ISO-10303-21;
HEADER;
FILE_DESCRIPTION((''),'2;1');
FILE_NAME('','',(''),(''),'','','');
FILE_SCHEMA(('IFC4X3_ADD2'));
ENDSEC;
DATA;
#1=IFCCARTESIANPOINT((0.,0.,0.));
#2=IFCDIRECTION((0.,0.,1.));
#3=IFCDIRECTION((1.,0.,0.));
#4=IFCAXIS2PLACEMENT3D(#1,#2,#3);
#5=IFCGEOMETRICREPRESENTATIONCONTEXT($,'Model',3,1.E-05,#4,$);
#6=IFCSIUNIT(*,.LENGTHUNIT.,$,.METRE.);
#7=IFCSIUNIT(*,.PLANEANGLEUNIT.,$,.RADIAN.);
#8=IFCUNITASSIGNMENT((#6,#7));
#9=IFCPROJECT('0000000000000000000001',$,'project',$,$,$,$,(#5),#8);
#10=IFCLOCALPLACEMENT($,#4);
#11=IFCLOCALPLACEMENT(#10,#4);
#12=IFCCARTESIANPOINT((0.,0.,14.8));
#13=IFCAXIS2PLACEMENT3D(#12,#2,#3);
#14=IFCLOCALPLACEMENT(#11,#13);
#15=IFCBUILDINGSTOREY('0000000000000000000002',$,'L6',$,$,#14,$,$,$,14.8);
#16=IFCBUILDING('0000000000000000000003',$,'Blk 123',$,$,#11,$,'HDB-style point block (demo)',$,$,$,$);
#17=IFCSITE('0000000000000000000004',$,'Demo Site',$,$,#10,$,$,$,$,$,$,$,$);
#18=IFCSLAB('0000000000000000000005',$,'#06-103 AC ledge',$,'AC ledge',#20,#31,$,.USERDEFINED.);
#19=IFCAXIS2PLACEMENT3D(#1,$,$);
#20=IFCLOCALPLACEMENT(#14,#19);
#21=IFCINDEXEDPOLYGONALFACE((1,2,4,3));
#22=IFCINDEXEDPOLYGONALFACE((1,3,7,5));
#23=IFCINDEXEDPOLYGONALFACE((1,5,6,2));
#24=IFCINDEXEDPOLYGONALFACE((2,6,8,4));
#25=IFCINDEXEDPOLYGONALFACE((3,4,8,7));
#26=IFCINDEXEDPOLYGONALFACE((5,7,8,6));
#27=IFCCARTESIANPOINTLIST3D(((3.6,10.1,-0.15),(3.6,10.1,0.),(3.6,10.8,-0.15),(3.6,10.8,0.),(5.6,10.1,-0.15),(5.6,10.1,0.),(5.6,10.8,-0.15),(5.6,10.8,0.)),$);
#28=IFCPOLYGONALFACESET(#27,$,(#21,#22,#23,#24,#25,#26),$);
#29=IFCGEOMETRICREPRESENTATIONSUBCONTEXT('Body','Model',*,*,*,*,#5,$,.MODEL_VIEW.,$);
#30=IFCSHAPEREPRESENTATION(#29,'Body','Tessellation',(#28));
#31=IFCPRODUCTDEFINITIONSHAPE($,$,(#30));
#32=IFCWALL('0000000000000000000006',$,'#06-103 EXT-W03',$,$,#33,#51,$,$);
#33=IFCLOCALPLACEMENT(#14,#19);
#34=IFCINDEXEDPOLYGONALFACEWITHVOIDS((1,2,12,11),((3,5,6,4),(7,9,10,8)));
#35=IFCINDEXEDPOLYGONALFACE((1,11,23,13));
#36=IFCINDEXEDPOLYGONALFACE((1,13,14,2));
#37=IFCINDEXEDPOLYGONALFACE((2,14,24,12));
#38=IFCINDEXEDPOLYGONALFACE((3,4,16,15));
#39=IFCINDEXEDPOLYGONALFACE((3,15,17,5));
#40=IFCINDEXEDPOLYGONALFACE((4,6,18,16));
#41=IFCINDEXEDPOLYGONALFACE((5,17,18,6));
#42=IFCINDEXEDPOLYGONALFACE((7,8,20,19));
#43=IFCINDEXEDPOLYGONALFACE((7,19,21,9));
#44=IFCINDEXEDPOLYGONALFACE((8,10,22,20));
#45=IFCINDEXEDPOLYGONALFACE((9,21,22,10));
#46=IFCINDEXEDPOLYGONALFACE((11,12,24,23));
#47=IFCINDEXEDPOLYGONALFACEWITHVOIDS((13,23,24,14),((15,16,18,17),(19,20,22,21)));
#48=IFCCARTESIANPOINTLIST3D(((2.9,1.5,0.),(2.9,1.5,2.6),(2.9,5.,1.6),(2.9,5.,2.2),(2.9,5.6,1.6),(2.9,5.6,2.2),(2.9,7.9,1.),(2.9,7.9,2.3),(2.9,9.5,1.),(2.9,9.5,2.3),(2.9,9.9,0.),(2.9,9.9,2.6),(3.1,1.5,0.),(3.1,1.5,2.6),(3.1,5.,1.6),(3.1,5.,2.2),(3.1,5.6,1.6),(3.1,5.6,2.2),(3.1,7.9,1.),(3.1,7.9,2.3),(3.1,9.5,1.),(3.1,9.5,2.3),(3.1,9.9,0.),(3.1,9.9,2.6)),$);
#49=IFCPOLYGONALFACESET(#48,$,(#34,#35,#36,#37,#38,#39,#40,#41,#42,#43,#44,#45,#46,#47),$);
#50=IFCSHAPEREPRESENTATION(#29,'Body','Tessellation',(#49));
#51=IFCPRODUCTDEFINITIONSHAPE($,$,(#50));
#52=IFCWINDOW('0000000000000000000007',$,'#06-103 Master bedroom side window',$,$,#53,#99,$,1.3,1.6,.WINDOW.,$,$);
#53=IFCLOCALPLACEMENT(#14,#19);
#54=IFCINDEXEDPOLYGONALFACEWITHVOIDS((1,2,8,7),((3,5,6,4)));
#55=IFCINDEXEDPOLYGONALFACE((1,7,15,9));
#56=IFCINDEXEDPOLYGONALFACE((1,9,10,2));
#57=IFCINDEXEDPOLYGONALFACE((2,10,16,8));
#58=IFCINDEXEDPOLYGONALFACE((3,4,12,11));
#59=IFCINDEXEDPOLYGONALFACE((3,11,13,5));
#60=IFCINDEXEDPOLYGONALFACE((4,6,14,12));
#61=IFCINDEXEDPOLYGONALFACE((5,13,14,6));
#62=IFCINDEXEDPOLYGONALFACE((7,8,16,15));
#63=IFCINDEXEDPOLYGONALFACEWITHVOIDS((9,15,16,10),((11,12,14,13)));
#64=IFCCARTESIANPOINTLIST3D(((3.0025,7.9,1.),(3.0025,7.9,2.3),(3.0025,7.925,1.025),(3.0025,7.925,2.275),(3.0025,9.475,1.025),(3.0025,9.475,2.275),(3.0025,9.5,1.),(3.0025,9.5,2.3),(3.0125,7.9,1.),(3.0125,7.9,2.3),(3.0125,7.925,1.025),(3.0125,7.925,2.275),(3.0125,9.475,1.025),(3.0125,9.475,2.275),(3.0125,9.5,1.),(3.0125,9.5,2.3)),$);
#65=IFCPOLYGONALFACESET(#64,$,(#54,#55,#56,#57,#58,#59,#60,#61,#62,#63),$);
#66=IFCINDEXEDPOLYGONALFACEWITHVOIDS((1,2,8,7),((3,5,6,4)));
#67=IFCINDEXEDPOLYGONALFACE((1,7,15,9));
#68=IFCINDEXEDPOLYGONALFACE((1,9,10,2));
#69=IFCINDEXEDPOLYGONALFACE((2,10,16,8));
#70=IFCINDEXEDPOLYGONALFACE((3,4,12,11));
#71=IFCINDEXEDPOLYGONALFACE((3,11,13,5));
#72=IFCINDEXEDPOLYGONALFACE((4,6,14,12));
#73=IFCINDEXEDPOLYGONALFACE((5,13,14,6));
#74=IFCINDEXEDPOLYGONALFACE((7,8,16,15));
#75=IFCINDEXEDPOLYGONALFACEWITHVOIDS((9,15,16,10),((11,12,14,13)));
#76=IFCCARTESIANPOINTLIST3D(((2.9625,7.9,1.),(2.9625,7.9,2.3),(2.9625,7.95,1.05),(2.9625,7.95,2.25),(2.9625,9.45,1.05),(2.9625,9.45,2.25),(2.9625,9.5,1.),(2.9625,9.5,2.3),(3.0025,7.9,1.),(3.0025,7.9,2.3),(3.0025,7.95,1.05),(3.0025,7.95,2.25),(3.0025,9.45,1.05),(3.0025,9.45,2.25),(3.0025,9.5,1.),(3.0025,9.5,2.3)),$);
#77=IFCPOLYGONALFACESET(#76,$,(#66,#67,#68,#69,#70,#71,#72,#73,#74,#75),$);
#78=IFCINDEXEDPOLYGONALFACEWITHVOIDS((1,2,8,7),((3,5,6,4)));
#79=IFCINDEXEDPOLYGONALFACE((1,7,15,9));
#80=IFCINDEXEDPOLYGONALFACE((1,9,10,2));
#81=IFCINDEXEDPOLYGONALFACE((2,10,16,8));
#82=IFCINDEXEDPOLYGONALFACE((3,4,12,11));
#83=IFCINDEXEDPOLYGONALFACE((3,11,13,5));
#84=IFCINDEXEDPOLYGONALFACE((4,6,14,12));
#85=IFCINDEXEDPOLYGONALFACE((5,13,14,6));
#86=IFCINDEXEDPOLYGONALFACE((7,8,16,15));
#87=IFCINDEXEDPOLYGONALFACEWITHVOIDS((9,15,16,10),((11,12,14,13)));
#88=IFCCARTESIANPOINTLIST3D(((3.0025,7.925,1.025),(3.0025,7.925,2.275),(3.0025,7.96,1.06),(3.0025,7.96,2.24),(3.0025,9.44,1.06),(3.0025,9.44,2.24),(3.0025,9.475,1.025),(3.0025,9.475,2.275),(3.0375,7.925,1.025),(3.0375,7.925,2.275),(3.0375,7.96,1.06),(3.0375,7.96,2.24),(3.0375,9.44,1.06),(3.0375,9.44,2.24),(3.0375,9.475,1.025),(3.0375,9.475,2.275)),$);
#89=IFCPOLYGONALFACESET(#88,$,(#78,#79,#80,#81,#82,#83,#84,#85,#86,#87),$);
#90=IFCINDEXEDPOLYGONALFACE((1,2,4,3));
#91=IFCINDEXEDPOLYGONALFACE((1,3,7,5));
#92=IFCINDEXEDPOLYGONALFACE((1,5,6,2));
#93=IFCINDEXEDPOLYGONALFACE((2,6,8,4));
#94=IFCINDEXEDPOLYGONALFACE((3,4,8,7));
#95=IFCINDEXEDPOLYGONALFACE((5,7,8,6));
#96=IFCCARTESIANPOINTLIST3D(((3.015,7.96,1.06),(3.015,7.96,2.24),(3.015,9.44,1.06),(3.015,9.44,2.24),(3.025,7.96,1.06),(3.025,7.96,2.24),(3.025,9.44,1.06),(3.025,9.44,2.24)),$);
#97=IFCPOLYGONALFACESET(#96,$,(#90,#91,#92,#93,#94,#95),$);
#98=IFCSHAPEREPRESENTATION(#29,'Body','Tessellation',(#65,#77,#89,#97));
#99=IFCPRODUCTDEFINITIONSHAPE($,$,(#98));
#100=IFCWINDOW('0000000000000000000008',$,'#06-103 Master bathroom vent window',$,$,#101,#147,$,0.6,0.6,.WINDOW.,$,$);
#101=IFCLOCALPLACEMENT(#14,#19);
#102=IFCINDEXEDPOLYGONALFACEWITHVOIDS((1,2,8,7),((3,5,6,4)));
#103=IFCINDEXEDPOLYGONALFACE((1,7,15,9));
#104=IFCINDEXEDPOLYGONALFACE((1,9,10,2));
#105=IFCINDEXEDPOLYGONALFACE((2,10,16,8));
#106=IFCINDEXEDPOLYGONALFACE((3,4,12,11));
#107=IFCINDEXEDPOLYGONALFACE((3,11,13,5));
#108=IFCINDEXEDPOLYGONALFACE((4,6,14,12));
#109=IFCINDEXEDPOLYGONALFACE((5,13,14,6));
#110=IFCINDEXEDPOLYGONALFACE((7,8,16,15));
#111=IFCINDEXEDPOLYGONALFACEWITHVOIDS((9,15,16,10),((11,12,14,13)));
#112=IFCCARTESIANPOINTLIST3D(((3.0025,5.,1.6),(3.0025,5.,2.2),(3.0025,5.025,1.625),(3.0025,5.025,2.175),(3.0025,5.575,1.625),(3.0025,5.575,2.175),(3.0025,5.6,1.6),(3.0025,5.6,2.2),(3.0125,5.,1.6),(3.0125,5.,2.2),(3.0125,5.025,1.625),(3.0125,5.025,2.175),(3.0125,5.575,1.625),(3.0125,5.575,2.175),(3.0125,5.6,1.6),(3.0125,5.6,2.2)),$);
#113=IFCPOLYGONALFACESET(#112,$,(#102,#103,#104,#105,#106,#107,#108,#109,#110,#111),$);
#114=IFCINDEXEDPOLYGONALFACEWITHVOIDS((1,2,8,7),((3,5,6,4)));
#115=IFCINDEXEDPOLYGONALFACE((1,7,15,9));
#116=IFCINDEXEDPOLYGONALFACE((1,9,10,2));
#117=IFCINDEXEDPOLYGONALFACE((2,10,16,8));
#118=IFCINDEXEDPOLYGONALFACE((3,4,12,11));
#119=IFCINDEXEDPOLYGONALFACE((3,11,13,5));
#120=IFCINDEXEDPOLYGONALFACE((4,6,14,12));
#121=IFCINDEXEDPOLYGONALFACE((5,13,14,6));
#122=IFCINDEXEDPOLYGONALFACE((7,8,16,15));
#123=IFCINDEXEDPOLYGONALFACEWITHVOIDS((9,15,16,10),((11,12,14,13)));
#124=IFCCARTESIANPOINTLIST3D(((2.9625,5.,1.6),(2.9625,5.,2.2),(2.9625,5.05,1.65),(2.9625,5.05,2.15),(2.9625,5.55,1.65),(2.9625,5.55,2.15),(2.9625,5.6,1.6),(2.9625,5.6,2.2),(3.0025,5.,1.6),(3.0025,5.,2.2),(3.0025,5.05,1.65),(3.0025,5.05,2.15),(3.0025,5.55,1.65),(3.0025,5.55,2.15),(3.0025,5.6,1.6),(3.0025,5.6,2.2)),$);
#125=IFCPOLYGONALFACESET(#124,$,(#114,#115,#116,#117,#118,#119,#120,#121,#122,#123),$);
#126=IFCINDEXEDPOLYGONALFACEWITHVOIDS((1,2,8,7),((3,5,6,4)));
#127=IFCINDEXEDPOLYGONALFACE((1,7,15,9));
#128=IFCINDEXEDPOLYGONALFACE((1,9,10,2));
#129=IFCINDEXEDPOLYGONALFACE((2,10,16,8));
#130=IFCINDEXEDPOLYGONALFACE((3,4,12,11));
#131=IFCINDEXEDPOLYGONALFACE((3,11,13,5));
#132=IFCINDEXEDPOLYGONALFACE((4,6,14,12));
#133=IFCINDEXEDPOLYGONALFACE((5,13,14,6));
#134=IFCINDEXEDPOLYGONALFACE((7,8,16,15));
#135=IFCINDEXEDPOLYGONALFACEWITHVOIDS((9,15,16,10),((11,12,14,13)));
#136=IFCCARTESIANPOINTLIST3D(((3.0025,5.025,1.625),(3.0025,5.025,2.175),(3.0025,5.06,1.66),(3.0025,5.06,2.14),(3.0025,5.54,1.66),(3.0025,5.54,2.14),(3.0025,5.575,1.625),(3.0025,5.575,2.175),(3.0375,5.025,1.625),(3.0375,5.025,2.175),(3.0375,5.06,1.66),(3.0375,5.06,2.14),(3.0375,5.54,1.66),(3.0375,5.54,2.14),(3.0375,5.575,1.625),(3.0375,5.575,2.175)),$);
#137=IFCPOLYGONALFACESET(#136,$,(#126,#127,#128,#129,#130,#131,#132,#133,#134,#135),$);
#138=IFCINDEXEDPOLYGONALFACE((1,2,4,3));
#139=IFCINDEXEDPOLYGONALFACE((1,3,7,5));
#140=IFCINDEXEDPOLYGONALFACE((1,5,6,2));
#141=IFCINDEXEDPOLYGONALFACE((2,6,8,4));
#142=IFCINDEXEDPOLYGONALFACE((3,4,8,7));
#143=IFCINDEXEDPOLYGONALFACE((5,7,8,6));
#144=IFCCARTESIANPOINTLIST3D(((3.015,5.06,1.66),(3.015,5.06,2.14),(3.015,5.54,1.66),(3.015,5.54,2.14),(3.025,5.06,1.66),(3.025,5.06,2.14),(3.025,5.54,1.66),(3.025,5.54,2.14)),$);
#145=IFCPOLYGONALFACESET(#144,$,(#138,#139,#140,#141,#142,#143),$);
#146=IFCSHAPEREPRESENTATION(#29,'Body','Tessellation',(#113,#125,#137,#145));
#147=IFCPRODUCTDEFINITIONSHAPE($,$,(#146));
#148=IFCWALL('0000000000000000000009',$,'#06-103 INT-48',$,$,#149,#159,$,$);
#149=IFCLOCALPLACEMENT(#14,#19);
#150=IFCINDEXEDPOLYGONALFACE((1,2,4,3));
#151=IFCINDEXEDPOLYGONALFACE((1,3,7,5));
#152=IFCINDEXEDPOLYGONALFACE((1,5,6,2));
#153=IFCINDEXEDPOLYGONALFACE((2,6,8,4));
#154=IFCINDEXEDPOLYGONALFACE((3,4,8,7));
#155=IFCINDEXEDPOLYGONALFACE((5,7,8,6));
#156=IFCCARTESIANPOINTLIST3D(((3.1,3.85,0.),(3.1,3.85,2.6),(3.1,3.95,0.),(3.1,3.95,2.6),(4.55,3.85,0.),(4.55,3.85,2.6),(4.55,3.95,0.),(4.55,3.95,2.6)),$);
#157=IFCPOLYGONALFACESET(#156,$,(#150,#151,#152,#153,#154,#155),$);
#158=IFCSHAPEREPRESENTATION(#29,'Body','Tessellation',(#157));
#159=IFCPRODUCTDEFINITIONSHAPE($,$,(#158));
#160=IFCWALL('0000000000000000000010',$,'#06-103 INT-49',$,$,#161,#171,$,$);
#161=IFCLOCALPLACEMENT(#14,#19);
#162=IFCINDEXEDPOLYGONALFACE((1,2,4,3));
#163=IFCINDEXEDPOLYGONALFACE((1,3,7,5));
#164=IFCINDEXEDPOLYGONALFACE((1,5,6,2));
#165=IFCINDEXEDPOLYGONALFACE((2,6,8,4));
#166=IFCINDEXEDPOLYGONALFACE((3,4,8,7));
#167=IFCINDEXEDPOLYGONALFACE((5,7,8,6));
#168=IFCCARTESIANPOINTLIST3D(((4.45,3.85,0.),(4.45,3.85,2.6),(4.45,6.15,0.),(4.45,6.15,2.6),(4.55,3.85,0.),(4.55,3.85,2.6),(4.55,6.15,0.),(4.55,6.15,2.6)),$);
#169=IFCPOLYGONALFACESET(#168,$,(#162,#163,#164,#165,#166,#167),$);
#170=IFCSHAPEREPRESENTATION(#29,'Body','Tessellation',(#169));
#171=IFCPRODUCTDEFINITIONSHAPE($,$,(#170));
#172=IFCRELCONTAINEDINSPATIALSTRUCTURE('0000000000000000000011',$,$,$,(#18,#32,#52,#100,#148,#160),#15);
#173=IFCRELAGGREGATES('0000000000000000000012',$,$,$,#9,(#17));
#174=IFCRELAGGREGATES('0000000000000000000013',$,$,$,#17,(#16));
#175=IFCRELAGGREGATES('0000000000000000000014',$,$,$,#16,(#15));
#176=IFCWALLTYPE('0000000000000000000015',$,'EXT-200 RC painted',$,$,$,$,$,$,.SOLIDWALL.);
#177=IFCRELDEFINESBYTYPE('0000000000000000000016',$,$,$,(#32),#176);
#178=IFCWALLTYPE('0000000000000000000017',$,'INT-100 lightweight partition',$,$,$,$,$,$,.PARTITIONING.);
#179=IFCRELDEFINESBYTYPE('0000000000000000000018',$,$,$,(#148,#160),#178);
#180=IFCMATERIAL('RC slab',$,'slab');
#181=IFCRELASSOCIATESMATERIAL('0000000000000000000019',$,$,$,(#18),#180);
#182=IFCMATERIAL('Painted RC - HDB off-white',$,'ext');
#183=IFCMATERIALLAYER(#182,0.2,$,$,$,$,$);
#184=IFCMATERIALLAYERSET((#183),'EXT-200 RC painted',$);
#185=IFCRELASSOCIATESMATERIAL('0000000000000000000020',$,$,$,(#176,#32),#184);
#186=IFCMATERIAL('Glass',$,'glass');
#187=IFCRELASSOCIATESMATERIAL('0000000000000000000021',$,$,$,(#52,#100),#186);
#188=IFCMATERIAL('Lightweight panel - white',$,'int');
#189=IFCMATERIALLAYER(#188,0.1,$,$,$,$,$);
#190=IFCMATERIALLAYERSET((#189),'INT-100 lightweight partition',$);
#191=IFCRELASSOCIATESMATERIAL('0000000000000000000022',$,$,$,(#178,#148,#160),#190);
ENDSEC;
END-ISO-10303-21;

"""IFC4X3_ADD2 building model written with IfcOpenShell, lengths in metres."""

from ifc_helpers import new_model, si_unit, frame, origin, origin_with_axes, place, context, subcontext, project, spatial, polyline, line, indexed_curve, outline, extrude, material, layer, layer_set, layer_usage, type_object, element, fill, save


model = new_model("IFC4X3_ADD2")

# Units and contexts
model_context = context("Model", 3, precision=1e-05, world=origin_with_axes())
body_context = subcontext(model_context, "Body", "Model", "MODEL_VIEW")
ifc_project = project(units=[si_unit("LENGTHUNIT", "METRE"), si_unit("PLANEANGLEUNIT", "RADIAN")], contexts=[model_context])

# Site, building, storey
site_placement = place(None, origin_with_axes())
site = spatial("IfcSite", under=ifc_project, at=site_placement, Name="Demo Site")
building_placement = place(site_placement, origin_with_axes())
building = spatial("IfcBuilding", under=site, at=building_placement, Name="Blk 123", LongName="HDB-style point block (demo)")
storey_placement = place(building_placement, frame((0.0, 0.0, 14.8), z_axis=(0.0, 0.0, 1.0), x_axis=(1.0, 0.0, 0.0)))
storey = spatial("IfcBuildingStorey", under=building, at=storey_placement, Name="L6", Elevation=14.8)

# Slab
ifc_material_1 = material(Name="RC slab", Category="slab")
slab_placement = place(storey_placement, frame((4.6, 10.45, -0.15), z_axis=(0.0, 0.0, 1.0), x_axis=(1.0, 0.0, 0.0)))
element("IfcSlab", 1, at=slab_placement, inside=storey, material=ifc_material_1, Name="#06-103 AC ledge", ObjectType="AC ledge", PredefinedType="USERDEFINED", context=body_context, shape_type="SweptSolid", body=[
    extrude(outline(polyline([(1.0, -0.35), (1.0, 0.35), (-1.0, 0.35), (-1.0, -0.35), (1.0, -0.35)])), origin(), (0.0, 0.0, 1.0), 0.15),
])

# Wall, openings, windows
ifc_material_2 = material(Name="Painted RC - HDB off-white", Category="ext")
ifc_layer_1 = layer(ifc_material_2, 0.2)
ifc_layer_set_1 = layer_set([ifc_layer_1], Name="EXT-200 RC painted")
ifc_layer_usage_1 = layer_usage(ifc_layer_set_1, "AXIS2", "POSITIVE", 0.0)
wall_type_1 = type_object("IfcWallType", Name="EXT-200 RC painted", PredefinedType="SOLIDWALL", material=ifc_layer_set_1)
wall_1_placement = place(storey_placement, frame((2.9, 9.9, 0.0), z_axis=(0.0, 0.0, 1.0), x_axis=(0.0, -1.0, 0.0)))
wall_1 = element("IfcWall", 2, at=wall_1_placement, inside=storey, type_object=wall_type_1, material=ifc_layer_usage_1, Name="#06-103 EXT-W03", context=body_context, shape_type="SweptSolid", body=[
    extrude(outline(indexed_curve([(0.0, 0.0), (0.0, 0.2), (8.4, 0.2), (8.4, 0.0), (0.0, 0.0)], self_intersect=False)), origin_with_axes(), (0.0, 0.0, 1.0), 2.6),
])
opening_1_placement = place(wall_1_placement, frame((0.4, -0.1, 1.0), z_axis=(0.0, 0.0, 1.0), x_axis=(1.0, 0.0, 0.0)))
opening_1 = element("IfcOpeningElement", 3, at=opening_1_placement, cuts=wall_1, context=body_context, shape_type="SweptSolid", body=[
    extrude(outline(indexed_curve([(0.0, 0.0), (0.0, 0.4), (1.6, 0.4), (1.6, 0.0), (0.0, 0.0)], self_intersect=False)), origin_with_axes(), (0.0, 0.0, 1.0), 1.3),
])
opening_2_placement = place(wall_1_placement, frame((4.3, -0.1, 1.6), z_axis=(0.0, 0.0, 1.0), x_axis=(1.0, 0.0, 0.0)))
opening_2 = element("IfcOpeningElement", 4, at=opening_2_placement, cuts=wall_1, context=body_context, shape_type="SweptSolid", body=[
    extrude(outline(indexed_curve([(0.0, 0.0), (0.0, 0.4), (0.6, 0.4), (0.6, 0.0), (0.0, 0.0)], self_intersect=False)), origin_with_axes(), (0.0, 0.0, 1.0), 0.6),
])
ifc_material_3 = material(Name="Glass", Category="glass")
window_1_placement = place(opening_1_placement, frame((0.0, 0.1125, 0.0), z_axis=(0.0, 0.0, 1.0), x_axis=(1.0, 0.0, 0.0)))
window_1 = element("IfcWindow", 5, at=window_1_placement, inside=storey, material=ifc_material_3, Name="#06-103 Master bedroom side window", OverallHeight=1.3, OverallWidth=1.6, PredefinedType="WINDOW", context=body_context, shape_type="SweptSolid", body=[
    extrude(outline(indexed_curve([(0.0, 0.0), (1.6, 0.0), (1.6, 1.3), (0.0, 1.3)], segments=[line(1, 2, 3, 4, 1)]), holes=[indexed_curve([(0.025, 0.025), (1.575, 0.025), (1.575, 1.275), (0.025, 1.275)], segments=[line(1, 2, 3, 4, 1)])]), frame((0.0, 0.09, 0.0), z_axis=(0.0, -1.0, 0.0), x_axis=(1.0, 0.0, 0.0)), (0.0, 0.0, -1.0), 0.01),
    extrude(outline(indexed_curve([(0.0, 0.0), (1.6, 0.0), (1.6, 1.3), (0.0, 1.3)], segments=[line(1, 2, 3, 4, 1)]), holes=[indexed_curve([(0.05, 0.05), (1.55, 0.05), (1.55, 1.25), (0.05, 1.25)], segments=[line(1, 2, 3, 4, 1)])]), frame((0.0, 0.05, 0.0), z_axis=(0.0, -1.0, 0.0), x_axis=(1.0, 0.0, 0.0)), (0.0, 0.0, -1.0), 0.04),
    extrude(outline(indexed_curve([(0.0, 0.0), (1.55, 0.0), (1.55, 1.25), (0.0, 1.25)], segments=[line(1, 2, 3, 4, 1)]), holes=[indexed_curve([(0.035, 0.035), (1.515, 0.035), (1.515, 1.215), (0.035, 1.215)], segments=[line(1, 2, 3, 4, 1)])]), frame((0.025, 0.09, 0.025), z_axis=(0.0, -1.0, 0.0), x_axis=(1.0, 0.0, 0.0)), (0.0, 0.0, -1.0), 0.035),
    extrude(outline(indexed_curve([(0.035, 0.035), (1.515, 0.035), (1.515, 1.215), (0.035, 1.215)], segments=[line(1, 2, 3, 4, 1)])), frame((0.025, 0.1025, 0.025), z_axis=(0.0, -1.0, 0.0), x_axis=(1.0, 0.0, 0.0)), (0.0, 0.0, -1.0), 0.01),
])
fill(opening_1, window_1)
window_2_placement = place(opening_2_placement, frame((0.0, 0.1125, 0.0), z_axis=(0.0, 0.0, 1.0), x_axis=(1.0, 0.0, 0.0)))
window_2 = element("IfcWindow", 6, at=window_2_placement, inside=storey, material=ifc_material_3, Name="#06-103 Master bathroom vent window", OverallHeight=0.6, OverallWidth=0.6, PredefinedType="WINDOW", context=body_context, shape_type="SweptSolid", body=[
    extrude(outline(indexed_curve([(0.0, 0.0), (0.6, 0.0), (0.6, 0.6), (0.0, 0.6)], segments=[line(1, 2, 3, 4, 1)]), holes=[indexed_curve([(0.025, 0.025), (0.575, 0.025), (0.575, 0.575), (0.025, 0.575)], segments=[line(1, 2, 3, 4, 1)])]), frame((0.0, 0.09, 0.0), z_axis=(0.0, -1.0, 0.0), x_axis=(1.0, 0.0, 0.0)), (0.0, 0.0, -1.0), 0.01),
    extrude(outline(indexed_curve([(0.0, 0.0), (0.6, 0.0), (0.6, 0.6), (0.0, 0.6)], segments=[line(1, 2, 3, 4, 1)]), holes=[indexed_curve([(0.05, 0.05), (0.55, 0.05), (0.55, 0.55), (0.05, 0.55)], segments=[line(1, 2, 3, 4, 1)])]), frame((0.0, 0.05, 0.0), z_axis=(0.0, -1.0, 0.0), x_axis=(1.0, 0.0, 0.0)), (0.0, 0.0, -1.0), 0.04),
    extrude(outline(indexed_curve([(0.0, 0.0), (0.55, 0.0), (0.55, 0.55), (0.0, 0.55)], segments=[line(1, 2, 3, 4, 1)]), holes=[indexed_curve([(0.035, 0.035), (0.515, 0.035), (0.515, 0.515), (0.035, 0.515)], segments=[line(1, 2, 3, 4, 1)])]), frame((0.025, 0.09, 0.025), z_axis=(0.0, -1.0, 0.0), x_axis=(1.0, 0.0, 0.0)), (0.0, 0.0, -1.0), 0.035),
    extrude(outline(indexed_curve([(0.035, 0.035), (0.515, 0.035), (0.515, 0.515), (0.035, 0.515)], segments=[line(1, 2, 3, 4, 1)])), frame((0.025, 0.1025, 0.025), z_axis=(0.0, -1.0, 0.0), x_axis=(1.0, 0.0, 0.0)), (0.0, 0.0, -1.0), 0.01),
])
fill(opening_2, window_2)

# Shared definitions
ifc_material_4 = material(Name="Lightweight panel - white", Category="int")
ifc_layer_2 = layer(ifc_material_4, 0.1)
ifc_layer_set_2 = layer_set([ifc_layer_2], Name="INT-100 lightweight partition")
ifc_layer_usage_2 = layer_usage(ifc_layer_set_2, "AXIS2", "POSITIVE", -0.05)
wall_type_2 = type_object("IfcWallType", Name="INT-100 lightweight partition", PredefinedType="PARTITIONING", material=ifc_layer_set_2)

# Walls
wall_2_placement = place(storey_placement, frame((3.1, 3.9, 0.0), z_axis=(0.0, 0.0, 1.0), x_axis=(1.0, 0.0, 0.0)))
element("IfcWall", 7, at=wall_2_placement, inside=storey, type_object=wall_type_2, material=ifc_layer_usage_2, Name="#06-103 INT-48", context=body_context, shape_type="SweptSolid", body=[
    extrude(outline(indexed_curve([(0.0, 0.0), (0.0, 0.1), (1.45, 0.1), (1.45, 0.0), (0.0, 0.0)], self_intersect=False)), frame((0.0, -0.05, 0.0), z_axis=(0.0, 0.0, 1.0), x_axis=(1.0, 0.0, 0.0)), (0.0, 0.0, 1.0), 2.6),
])
wall_3_placement = place(storey_placement, frame((4.5, 3.85, 0.0), z_axis=(0.0, 0.0, 1.0), x_axis=(0.0, 1.0, 0.0)))
element("IfcWall", 8, at=wall_3_placement, inside=storey, type_object=wall_type_2, material=ifc_layer_usage_2, Name="#06-103 INT-49", context=body_context, shape_type="SweptSolid", body=[
    extrude(outline(indexed_curve([(0.0, 0.0), (0.0, 0.1), (2.3, 0.1), (2.3, 0.0), (0.0, 0.0)], self_intersect=False)), frame((0.0, -0.05, 0.0), z_axis=(0.0, 0.0, 1.0), x_axis=(1.0, 0.0, 0.0)), (0.0, 0.0, 1.0), 2.6),
])

save(model, "model.ifc")
